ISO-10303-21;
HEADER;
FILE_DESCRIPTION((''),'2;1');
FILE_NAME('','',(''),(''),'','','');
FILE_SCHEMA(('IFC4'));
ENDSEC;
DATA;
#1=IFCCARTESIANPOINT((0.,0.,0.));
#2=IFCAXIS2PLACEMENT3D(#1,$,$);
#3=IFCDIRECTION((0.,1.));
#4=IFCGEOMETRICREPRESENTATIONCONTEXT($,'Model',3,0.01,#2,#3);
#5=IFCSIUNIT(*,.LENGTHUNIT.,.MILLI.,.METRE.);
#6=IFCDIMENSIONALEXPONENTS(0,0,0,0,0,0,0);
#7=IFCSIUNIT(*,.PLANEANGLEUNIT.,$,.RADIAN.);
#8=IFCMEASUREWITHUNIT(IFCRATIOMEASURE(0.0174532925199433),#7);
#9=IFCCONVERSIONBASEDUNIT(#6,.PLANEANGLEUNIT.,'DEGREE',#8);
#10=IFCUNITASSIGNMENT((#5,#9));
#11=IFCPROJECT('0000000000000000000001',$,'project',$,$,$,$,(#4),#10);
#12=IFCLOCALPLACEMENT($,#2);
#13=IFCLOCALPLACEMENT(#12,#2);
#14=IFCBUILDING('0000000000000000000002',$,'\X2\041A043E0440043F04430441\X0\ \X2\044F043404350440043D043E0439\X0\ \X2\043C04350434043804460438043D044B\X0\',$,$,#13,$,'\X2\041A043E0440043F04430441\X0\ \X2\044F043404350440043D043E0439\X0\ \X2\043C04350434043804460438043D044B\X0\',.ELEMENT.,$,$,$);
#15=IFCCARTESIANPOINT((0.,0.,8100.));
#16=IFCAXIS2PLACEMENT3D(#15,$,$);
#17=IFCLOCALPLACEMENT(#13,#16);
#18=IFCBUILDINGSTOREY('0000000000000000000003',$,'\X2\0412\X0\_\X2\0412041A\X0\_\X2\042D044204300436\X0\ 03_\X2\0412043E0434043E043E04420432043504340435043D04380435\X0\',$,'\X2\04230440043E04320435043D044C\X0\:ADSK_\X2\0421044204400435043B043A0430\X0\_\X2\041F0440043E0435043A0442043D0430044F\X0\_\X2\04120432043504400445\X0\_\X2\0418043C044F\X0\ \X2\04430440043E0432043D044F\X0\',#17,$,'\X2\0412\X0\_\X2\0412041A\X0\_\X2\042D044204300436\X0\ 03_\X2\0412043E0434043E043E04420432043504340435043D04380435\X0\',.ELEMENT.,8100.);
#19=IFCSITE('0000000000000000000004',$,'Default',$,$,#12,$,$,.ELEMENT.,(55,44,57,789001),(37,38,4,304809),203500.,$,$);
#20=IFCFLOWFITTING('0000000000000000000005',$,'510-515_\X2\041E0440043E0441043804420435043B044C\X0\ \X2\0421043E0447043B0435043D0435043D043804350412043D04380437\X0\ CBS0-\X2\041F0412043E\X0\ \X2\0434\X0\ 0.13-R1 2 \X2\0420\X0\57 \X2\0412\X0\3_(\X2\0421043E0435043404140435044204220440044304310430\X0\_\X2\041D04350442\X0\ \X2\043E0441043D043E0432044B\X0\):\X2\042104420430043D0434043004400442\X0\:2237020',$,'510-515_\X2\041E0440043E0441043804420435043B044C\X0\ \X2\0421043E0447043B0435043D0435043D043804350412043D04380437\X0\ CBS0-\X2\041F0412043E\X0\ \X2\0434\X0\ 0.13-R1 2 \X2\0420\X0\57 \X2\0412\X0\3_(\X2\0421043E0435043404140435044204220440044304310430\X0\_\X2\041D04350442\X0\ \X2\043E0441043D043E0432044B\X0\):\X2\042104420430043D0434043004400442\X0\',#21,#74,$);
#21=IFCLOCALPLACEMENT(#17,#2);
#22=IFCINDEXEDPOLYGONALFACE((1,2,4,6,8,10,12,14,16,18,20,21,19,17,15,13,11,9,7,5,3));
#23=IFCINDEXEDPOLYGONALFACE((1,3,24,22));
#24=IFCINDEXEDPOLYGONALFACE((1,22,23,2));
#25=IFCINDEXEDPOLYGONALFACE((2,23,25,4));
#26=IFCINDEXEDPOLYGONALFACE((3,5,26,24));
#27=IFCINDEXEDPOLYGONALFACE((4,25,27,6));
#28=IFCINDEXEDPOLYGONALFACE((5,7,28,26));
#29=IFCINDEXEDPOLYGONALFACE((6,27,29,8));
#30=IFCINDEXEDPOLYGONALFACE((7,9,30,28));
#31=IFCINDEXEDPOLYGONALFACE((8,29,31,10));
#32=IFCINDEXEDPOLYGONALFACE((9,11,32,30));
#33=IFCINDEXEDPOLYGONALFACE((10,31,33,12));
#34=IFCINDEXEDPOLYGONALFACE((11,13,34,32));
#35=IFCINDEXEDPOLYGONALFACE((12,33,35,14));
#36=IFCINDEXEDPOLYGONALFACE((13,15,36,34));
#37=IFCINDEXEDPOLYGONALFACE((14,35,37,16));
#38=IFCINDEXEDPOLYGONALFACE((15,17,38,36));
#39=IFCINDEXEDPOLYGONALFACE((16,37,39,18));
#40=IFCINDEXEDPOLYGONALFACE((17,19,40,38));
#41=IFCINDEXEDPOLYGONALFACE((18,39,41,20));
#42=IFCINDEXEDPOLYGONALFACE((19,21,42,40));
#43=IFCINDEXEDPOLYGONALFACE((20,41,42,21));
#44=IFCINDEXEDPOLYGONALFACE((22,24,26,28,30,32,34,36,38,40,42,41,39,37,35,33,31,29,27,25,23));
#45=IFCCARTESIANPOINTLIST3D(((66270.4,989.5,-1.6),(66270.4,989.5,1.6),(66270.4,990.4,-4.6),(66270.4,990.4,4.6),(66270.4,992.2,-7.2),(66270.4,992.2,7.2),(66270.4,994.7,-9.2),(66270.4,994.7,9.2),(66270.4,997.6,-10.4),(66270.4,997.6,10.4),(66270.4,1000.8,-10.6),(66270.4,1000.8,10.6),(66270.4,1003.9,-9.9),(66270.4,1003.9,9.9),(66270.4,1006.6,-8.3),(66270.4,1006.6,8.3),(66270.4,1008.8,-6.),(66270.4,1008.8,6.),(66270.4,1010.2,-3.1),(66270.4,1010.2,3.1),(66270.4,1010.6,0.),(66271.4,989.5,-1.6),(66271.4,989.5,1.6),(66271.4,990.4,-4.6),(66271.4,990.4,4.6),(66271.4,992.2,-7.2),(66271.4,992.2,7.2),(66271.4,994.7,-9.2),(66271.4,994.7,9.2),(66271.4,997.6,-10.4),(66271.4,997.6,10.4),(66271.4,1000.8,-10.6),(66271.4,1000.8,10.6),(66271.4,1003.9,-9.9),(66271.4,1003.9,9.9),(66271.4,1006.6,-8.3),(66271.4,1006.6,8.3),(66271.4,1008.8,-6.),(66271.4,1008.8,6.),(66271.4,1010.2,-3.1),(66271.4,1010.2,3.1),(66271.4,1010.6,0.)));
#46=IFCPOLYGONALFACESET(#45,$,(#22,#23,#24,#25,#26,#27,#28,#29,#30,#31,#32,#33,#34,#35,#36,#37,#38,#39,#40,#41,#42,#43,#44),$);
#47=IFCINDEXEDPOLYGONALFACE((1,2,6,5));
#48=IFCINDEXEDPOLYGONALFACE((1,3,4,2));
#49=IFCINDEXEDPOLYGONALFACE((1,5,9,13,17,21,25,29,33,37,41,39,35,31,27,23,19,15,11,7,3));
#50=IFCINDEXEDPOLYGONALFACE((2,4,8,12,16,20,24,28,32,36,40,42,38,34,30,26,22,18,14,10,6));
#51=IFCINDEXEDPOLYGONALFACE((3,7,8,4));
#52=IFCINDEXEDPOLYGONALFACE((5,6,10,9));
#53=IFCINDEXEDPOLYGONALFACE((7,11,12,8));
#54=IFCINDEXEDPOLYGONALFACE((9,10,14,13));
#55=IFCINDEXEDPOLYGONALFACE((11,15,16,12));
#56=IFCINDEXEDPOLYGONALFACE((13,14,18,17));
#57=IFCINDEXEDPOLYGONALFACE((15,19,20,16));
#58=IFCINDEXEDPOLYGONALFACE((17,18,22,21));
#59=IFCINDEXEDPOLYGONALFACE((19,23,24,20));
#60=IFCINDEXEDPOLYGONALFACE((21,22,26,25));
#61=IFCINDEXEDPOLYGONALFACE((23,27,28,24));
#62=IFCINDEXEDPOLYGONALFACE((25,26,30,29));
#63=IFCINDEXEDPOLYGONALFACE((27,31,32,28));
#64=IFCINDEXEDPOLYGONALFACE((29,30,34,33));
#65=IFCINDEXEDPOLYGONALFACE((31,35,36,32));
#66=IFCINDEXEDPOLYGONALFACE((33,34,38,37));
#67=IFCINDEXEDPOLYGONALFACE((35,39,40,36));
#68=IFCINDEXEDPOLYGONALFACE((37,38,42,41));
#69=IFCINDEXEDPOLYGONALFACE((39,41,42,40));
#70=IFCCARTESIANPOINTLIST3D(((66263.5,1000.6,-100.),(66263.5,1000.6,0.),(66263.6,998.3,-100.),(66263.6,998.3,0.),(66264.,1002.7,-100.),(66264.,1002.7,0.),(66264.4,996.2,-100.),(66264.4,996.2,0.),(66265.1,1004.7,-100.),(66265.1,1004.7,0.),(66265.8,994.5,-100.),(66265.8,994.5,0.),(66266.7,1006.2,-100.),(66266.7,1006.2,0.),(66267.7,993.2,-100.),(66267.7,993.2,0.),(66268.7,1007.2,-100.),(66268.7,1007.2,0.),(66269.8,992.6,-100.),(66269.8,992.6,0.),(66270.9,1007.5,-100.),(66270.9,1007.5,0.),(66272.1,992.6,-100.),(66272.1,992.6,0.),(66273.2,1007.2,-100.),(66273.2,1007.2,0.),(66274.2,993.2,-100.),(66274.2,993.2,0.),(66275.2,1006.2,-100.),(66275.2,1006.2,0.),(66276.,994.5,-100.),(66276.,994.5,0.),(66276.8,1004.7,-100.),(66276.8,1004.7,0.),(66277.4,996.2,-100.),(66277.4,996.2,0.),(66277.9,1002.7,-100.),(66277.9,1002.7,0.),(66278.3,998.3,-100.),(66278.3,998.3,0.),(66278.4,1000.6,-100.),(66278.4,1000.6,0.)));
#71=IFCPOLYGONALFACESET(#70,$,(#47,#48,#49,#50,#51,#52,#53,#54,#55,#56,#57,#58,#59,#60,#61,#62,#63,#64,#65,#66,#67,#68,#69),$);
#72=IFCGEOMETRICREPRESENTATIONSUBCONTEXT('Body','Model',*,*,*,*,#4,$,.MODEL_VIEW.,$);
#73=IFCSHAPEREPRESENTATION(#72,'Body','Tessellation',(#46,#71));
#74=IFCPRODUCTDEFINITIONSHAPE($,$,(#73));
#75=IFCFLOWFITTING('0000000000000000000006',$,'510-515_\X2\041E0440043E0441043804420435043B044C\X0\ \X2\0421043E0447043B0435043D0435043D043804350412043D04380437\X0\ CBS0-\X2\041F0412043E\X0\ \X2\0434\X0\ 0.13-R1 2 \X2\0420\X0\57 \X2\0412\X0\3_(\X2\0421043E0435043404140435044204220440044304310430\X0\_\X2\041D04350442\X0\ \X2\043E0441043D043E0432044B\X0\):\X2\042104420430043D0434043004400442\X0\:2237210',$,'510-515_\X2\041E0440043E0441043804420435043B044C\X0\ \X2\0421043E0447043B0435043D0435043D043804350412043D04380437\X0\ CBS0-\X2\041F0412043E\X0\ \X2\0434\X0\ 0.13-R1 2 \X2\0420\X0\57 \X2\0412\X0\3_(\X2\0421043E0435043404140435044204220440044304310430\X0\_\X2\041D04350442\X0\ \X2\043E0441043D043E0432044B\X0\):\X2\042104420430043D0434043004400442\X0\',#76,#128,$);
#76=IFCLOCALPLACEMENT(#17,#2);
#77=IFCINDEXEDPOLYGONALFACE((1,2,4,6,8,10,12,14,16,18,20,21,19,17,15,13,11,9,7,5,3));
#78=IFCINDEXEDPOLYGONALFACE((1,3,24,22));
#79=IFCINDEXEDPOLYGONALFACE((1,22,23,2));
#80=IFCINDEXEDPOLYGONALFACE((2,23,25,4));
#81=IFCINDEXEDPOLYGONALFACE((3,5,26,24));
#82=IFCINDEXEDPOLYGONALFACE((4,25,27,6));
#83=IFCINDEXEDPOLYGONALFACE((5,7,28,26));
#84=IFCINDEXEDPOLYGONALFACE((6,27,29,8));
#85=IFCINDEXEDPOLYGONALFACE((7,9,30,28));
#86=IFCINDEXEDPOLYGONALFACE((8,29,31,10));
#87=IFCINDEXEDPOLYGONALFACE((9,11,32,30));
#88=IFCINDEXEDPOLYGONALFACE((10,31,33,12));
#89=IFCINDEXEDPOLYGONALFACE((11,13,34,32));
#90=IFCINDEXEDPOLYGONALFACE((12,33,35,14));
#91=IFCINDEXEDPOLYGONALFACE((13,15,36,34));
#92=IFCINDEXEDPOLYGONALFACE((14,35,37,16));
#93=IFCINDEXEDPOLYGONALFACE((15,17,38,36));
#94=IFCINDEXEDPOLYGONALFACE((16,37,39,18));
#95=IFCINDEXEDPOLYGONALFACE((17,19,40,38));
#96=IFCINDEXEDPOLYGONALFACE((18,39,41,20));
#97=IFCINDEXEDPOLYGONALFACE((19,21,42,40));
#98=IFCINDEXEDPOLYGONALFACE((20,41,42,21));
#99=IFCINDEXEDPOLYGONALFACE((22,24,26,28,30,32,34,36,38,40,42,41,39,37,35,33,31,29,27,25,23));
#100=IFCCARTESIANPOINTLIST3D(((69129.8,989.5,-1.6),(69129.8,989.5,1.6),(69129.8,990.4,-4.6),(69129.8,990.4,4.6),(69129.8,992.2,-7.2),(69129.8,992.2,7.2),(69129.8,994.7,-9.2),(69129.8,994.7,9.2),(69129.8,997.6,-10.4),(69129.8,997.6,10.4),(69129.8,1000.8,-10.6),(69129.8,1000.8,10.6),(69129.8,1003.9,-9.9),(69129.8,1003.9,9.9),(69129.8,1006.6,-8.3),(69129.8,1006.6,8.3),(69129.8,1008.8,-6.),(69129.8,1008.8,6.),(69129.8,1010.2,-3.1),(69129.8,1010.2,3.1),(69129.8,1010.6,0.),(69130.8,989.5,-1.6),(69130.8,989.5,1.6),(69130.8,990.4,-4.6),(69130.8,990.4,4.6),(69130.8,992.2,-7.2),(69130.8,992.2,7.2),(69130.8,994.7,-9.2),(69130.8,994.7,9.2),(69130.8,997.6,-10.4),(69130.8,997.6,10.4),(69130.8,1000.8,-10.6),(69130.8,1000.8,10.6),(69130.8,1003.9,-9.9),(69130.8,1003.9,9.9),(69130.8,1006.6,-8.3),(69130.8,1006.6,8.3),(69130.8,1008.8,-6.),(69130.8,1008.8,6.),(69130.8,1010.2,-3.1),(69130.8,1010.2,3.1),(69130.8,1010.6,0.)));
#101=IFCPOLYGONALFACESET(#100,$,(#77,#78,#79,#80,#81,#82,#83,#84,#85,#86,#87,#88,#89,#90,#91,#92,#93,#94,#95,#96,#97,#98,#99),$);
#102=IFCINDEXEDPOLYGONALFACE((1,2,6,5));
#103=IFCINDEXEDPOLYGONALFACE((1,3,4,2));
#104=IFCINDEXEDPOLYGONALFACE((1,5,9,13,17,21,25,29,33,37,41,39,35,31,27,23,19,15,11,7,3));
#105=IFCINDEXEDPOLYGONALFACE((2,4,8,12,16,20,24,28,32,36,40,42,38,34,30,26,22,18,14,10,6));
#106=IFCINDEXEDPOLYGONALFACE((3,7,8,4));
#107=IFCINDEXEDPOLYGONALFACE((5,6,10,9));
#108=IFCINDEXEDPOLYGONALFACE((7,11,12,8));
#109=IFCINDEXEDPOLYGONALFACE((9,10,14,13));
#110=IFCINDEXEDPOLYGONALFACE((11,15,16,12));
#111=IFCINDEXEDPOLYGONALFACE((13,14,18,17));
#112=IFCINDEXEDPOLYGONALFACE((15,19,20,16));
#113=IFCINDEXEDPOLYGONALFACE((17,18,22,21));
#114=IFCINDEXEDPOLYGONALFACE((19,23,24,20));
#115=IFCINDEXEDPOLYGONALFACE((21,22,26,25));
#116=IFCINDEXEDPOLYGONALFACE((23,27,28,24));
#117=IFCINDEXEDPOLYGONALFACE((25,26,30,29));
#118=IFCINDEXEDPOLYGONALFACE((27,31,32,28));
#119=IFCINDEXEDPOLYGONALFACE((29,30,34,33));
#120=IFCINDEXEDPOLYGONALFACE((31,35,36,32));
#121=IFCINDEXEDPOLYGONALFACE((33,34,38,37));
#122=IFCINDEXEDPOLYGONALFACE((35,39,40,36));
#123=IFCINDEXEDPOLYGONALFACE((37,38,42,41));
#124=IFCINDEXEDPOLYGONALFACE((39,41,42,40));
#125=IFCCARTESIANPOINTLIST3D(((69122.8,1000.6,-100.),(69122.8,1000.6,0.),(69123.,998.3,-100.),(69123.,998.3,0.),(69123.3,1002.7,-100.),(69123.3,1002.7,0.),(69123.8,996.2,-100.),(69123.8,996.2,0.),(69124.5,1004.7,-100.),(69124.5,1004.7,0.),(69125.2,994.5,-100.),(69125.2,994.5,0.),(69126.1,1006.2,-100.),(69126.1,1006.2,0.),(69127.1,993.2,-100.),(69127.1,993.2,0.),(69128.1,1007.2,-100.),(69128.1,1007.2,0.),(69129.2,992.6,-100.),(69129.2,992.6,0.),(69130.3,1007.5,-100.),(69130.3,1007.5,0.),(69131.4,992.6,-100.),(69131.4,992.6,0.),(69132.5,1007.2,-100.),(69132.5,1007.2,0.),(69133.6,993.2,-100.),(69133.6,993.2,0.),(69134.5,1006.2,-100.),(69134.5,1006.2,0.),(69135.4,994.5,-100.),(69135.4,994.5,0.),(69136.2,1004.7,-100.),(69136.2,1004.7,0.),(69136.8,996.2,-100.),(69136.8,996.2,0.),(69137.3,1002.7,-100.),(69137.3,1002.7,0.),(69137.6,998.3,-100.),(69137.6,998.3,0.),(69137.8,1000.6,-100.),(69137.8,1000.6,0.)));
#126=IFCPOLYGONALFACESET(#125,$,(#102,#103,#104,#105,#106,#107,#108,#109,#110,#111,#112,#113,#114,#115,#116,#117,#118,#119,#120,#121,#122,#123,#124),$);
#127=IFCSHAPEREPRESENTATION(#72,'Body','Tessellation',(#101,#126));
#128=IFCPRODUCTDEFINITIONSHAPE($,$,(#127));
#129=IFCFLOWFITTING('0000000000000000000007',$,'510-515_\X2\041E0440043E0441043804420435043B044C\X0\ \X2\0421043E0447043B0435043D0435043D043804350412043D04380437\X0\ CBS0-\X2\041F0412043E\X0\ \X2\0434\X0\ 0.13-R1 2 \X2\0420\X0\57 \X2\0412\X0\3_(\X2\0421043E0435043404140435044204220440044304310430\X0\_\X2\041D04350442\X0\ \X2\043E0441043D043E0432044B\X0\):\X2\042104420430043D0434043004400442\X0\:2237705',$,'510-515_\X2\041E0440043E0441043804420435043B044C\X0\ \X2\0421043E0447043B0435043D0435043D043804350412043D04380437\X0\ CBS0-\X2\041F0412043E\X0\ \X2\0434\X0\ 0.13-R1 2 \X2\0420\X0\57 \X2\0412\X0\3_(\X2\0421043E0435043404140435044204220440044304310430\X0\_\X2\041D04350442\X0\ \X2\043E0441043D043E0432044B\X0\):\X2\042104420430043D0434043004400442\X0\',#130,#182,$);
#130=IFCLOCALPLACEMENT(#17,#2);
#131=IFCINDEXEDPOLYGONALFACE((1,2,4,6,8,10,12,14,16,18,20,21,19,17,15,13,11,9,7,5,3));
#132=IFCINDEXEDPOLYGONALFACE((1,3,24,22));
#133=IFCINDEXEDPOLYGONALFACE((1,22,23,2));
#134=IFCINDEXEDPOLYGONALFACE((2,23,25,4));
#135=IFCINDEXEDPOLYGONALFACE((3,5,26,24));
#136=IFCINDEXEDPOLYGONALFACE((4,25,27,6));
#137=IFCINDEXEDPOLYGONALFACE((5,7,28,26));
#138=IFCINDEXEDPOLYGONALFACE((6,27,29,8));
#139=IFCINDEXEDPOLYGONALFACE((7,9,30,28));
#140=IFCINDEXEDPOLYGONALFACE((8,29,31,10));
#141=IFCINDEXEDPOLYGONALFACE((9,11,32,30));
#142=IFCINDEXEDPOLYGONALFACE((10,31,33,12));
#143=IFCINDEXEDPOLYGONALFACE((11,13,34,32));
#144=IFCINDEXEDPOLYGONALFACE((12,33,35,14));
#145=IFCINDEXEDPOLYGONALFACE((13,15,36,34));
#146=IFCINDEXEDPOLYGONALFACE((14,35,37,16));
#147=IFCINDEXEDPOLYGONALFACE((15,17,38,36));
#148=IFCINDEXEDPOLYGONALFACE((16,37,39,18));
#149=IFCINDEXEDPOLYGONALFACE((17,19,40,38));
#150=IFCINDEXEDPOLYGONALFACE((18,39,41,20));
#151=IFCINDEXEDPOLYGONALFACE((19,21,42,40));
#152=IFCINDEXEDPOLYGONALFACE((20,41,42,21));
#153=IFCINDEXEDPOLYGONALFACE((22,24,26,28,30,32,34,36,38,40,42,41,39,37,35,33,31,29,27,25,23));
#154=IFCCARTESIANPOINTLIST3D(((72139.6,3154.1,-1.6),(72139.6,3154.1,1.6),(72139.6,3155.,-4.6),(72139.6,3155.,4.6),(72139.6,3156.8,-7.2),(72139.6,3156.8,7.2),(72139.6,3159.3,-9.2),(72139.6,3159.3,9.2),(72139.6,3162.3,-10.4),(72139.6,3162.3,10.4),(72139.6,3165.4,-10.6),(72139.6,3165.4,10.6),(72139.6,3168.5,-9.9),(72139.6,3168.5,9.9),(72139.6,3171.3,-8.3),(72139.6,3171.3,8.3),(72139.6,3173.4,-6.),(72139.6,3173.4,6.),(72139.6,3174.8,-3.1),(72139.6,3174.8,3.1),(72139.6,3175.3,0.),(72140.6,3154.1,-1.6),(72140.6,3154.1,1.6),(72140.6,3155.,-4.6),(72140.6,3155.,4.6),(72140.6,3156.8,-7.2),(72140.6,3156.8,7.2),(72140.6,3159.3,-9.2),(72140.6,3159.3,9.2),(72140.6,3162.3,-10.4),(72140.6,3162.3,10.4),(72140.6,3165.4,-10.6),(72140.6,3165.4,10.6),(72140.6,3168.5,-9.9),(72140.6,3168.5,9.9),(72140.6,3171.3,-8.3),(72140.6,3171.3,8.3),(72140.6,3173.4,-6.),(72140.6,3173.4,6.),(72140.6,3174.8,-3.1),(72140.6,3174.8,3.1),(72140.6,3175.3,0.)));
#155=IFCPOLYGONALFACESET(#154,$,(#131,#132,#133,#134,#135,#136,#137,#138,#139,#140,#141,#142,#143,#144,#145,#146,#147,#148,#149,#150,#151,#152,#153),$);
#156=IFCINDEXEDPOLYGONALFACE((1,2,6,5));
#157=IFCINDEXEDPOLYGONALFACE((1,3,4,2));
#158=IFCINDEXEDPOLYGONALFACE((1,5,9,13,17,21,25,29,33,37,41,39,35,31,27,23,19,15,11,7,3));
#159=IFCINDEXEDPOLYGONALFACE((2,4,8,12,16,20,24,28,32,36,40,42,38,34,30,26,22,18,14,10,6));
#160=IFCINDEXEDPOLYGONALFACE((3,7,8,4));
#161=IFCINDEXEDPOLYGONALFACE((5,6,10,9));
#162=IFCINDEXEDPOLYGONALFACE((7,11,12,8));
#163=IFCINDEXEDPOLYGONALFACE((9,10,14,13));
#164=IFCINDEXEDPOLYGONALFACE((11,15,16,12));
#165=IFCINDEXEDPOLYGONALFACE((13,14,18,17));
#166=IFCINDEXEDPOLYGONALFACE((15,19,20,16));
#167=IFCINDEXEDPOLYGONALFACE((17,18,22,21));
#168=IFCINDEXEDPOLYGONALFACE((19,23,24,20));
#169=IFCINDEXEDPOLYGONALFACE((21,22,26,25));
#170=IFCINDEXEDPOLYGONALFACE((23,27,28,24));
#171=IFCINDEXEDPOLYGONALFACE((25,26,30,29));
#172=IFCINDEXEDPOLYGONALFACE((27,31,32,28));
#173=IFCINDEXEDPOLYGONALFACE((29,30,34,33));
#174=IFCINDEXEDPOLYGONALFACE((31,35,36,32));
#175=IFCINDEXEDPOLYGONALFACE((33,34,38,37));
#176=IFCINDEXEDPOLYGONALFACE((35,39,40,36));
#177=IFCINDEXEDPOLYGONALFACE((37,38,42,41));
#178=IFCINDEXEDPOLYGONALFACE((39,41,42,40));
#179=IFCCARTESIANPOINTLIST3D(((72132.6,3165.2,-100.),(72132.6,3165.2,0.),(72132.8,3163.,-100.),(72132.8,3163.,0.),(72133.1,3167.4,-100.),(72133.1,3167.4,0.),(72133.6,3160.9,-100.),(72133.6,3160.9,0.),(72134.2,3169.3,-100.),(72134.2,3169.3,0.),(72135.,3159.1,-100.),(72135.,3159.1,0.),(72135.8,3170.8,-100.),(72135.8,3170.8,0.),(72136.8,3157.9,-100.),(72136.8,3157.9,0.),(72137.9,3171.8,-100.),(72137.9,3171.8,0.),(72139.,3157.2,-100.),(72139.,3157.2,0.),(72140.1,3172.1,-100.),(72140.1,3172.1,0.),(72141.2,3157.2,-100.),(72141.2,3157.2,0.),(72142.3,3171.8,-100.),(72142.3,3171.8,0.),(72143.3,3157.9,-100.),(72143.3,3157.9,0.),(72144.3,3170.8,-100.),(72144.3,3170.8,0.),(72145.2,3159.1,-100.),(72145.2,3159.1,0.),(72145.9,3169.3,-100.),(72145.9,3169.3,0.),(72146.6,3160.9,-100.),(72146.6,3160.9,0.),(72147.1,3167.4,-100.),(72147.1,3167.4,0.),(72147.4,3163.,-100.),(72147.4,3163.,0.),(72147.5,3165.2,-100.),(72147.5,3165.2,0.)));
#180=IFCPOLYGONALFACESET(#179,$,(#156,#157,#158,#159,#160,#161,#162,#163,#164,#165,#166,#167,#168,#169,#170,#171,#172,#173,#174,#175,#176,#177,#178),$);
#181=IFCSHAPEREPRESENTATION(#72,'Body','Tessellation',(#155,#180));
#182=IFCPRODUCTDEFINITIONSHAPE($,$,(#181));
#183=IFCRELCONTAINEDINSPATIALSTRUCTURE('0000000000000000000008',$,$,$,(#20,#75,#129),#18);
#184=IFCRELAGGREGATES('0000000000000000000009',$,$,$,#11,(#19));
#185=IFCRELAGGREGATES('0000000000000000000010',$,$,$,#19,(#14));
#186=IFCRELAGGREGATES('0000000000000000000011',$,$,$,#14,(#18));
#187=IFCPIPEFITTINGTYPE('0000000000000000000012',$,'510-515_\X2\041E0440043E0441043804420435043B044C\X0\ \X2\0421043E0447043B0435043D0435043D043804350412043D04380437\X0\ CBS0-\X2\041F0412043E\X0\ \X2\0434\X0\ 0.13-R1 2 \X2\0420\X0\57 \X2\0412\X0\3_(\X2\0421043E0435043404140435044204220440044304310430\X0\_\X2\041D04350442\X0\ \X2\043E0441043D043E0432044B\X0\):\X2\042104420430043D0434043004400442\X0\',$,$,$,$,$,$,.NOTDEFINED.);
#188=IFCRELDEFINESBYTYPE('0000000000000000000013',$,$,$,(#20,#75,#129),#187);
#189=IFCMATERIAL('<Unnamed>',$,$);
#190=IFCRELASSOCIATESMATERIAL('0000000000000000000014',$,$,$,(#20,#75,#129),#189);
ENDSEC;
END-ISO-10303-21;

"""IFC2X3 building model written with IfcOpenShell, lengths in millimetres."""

from ifc_helpers import new_model, entity, si_unit, converted_unit, direction, frame, origin, origin_2d_with_axis, place, context, subcontext, project, spatial, circle, extrude, source, transform, mapped, material, type_object, type_shapes, element, save


model = new_model("IFC2X3")

# Units and contexts
model_context = context("Model", 3, precision=0.01, world=origin(), true_north=direction((0.0, 1.0)))
body_context = subcontext(model_context, "Body", "Model", "MODEL_VIEW")
ifc_project = project(units=[si_unit("LENGTHUNIT", "METRE", prefix="MILLI"), converted_unit("PLANEANGLEUNIT", "DEGREE", entity("IfcRatioMeasure", 0.0174532925199433), si_unit("PLANEANGLEUNIT", "RADIAN"), dimensions=[0, 0, 0, 0, 0, 0, 0])], contexts=[model_context])

# Site, building, storey
site_placement = place(None, origin())
site = spatial("IfcSite", under=ifc_project, at=site_placement, Name="Default", CompositionType="ELEMENT", RefLatitude=(55, 44, 57, 789001), RefLongitude=(37, 38, 4, 304809), RefElevation=203500.0)
building_placement = place(site_placement, origin())
building = spatial("IfcBuilding", under=site, at=building_placement, Name="Корпус ядерной медицины", LongName="Корпус ядерной медицины", CompositionType="ELEMENT")
storey_placement = place(building_placement, frame((0.0, 0.0, 8100.0)))
storey = spatial("IfcBuildingStorey", under=building, at=storey_placement, Name="В_ВК_Этаж 03_Водоотведение", ObjectType="Уровень:ADSK_Стрелка_Проектная_Вверх_Имя уровня", LongName="В_ВК_Этаж 03_Водоотведение", CompositionType="ELEMENT", Elevation=8100.0)

# Flow fittings
ifc_material_1 = material(Name="<Unnamed>")
pipe_fitting_type = type_object("IfcPipeFittingType", Name="510-515_Ороситель СочленениеВниз CBS0-ПВо д 0.13-R1 2 Р57 В3_(СоедДетТруба_Нет основы):Стандарт", PredefinedType="NOTDEFINED")
shared_shape_1 = source(origin(), body_context, "Body", "SweptSolid", [
    extrude(circle(Radius=10.7, at=origin_2d_with_axis()), frame((-0.5, 0.0, 0.0), z_axis=(1.0, 0.0, 0.0), x_axis=(0.0, 1.0, 0.0)), (0.0, 0.0, 1.0), 1.0),
    extrude(circle(Radius=7.5, at=origin_2d_with_axis()), frame((0.0, 0.0, -100.0), z_axis=(0.0, 0.0, 1.0), x_axis=(0.0, 1.0, 0.0)), (0.0, 0.0, 1.0), 100.0),
])
type_shapes(pipe_fitting_type, [shared_shape_1])
for number, where, name in (
    (1, (66270.9, 1000.0, 0.0), "510-515_Ороситель СочленениеВниз CBS0-ПВо д 0.13-R1 2 Р57 В3_(СоедДетТруба_Нет основы):Стандарт:2237020"),
    (2, (69130.3, 1000.0, 0.0), "510-515_Ороситель СочленениеВниз CBS0-ПВо д 0.13-R1 2 Р57 В3_(СоедДетТруба_Нет основы):Стандарт:2237210"),
    (3, (72140.1, 3164.6, 0.0), "510-515_Ороситель СочленениеВниз CBS0-ПВо д 0.13-R1 2 Р57 В3_(СоедДетТруба_Нет основы):Стандарт:2237705"),
):
    element("IfcFlowFitting", number, at=place(storey_placement, frame(where)), inside=storey, type_object=pipe_fitting_type, material=ifc_material_1, Name=name, ObjectType="510-515_Ороситель СочленениеВниз CBS0-ПВо д 0.13-R1 2 Р57 В3_(СоедДетТруба_Нет основы):Стандарт", context=body_context, shape_type="MappedRepresentation", body=[
        mapped(shared_shape_1, transform((0.0, 0.0, 0.0), scale=1.0)),
    ])

save(model, "model.ifc")
